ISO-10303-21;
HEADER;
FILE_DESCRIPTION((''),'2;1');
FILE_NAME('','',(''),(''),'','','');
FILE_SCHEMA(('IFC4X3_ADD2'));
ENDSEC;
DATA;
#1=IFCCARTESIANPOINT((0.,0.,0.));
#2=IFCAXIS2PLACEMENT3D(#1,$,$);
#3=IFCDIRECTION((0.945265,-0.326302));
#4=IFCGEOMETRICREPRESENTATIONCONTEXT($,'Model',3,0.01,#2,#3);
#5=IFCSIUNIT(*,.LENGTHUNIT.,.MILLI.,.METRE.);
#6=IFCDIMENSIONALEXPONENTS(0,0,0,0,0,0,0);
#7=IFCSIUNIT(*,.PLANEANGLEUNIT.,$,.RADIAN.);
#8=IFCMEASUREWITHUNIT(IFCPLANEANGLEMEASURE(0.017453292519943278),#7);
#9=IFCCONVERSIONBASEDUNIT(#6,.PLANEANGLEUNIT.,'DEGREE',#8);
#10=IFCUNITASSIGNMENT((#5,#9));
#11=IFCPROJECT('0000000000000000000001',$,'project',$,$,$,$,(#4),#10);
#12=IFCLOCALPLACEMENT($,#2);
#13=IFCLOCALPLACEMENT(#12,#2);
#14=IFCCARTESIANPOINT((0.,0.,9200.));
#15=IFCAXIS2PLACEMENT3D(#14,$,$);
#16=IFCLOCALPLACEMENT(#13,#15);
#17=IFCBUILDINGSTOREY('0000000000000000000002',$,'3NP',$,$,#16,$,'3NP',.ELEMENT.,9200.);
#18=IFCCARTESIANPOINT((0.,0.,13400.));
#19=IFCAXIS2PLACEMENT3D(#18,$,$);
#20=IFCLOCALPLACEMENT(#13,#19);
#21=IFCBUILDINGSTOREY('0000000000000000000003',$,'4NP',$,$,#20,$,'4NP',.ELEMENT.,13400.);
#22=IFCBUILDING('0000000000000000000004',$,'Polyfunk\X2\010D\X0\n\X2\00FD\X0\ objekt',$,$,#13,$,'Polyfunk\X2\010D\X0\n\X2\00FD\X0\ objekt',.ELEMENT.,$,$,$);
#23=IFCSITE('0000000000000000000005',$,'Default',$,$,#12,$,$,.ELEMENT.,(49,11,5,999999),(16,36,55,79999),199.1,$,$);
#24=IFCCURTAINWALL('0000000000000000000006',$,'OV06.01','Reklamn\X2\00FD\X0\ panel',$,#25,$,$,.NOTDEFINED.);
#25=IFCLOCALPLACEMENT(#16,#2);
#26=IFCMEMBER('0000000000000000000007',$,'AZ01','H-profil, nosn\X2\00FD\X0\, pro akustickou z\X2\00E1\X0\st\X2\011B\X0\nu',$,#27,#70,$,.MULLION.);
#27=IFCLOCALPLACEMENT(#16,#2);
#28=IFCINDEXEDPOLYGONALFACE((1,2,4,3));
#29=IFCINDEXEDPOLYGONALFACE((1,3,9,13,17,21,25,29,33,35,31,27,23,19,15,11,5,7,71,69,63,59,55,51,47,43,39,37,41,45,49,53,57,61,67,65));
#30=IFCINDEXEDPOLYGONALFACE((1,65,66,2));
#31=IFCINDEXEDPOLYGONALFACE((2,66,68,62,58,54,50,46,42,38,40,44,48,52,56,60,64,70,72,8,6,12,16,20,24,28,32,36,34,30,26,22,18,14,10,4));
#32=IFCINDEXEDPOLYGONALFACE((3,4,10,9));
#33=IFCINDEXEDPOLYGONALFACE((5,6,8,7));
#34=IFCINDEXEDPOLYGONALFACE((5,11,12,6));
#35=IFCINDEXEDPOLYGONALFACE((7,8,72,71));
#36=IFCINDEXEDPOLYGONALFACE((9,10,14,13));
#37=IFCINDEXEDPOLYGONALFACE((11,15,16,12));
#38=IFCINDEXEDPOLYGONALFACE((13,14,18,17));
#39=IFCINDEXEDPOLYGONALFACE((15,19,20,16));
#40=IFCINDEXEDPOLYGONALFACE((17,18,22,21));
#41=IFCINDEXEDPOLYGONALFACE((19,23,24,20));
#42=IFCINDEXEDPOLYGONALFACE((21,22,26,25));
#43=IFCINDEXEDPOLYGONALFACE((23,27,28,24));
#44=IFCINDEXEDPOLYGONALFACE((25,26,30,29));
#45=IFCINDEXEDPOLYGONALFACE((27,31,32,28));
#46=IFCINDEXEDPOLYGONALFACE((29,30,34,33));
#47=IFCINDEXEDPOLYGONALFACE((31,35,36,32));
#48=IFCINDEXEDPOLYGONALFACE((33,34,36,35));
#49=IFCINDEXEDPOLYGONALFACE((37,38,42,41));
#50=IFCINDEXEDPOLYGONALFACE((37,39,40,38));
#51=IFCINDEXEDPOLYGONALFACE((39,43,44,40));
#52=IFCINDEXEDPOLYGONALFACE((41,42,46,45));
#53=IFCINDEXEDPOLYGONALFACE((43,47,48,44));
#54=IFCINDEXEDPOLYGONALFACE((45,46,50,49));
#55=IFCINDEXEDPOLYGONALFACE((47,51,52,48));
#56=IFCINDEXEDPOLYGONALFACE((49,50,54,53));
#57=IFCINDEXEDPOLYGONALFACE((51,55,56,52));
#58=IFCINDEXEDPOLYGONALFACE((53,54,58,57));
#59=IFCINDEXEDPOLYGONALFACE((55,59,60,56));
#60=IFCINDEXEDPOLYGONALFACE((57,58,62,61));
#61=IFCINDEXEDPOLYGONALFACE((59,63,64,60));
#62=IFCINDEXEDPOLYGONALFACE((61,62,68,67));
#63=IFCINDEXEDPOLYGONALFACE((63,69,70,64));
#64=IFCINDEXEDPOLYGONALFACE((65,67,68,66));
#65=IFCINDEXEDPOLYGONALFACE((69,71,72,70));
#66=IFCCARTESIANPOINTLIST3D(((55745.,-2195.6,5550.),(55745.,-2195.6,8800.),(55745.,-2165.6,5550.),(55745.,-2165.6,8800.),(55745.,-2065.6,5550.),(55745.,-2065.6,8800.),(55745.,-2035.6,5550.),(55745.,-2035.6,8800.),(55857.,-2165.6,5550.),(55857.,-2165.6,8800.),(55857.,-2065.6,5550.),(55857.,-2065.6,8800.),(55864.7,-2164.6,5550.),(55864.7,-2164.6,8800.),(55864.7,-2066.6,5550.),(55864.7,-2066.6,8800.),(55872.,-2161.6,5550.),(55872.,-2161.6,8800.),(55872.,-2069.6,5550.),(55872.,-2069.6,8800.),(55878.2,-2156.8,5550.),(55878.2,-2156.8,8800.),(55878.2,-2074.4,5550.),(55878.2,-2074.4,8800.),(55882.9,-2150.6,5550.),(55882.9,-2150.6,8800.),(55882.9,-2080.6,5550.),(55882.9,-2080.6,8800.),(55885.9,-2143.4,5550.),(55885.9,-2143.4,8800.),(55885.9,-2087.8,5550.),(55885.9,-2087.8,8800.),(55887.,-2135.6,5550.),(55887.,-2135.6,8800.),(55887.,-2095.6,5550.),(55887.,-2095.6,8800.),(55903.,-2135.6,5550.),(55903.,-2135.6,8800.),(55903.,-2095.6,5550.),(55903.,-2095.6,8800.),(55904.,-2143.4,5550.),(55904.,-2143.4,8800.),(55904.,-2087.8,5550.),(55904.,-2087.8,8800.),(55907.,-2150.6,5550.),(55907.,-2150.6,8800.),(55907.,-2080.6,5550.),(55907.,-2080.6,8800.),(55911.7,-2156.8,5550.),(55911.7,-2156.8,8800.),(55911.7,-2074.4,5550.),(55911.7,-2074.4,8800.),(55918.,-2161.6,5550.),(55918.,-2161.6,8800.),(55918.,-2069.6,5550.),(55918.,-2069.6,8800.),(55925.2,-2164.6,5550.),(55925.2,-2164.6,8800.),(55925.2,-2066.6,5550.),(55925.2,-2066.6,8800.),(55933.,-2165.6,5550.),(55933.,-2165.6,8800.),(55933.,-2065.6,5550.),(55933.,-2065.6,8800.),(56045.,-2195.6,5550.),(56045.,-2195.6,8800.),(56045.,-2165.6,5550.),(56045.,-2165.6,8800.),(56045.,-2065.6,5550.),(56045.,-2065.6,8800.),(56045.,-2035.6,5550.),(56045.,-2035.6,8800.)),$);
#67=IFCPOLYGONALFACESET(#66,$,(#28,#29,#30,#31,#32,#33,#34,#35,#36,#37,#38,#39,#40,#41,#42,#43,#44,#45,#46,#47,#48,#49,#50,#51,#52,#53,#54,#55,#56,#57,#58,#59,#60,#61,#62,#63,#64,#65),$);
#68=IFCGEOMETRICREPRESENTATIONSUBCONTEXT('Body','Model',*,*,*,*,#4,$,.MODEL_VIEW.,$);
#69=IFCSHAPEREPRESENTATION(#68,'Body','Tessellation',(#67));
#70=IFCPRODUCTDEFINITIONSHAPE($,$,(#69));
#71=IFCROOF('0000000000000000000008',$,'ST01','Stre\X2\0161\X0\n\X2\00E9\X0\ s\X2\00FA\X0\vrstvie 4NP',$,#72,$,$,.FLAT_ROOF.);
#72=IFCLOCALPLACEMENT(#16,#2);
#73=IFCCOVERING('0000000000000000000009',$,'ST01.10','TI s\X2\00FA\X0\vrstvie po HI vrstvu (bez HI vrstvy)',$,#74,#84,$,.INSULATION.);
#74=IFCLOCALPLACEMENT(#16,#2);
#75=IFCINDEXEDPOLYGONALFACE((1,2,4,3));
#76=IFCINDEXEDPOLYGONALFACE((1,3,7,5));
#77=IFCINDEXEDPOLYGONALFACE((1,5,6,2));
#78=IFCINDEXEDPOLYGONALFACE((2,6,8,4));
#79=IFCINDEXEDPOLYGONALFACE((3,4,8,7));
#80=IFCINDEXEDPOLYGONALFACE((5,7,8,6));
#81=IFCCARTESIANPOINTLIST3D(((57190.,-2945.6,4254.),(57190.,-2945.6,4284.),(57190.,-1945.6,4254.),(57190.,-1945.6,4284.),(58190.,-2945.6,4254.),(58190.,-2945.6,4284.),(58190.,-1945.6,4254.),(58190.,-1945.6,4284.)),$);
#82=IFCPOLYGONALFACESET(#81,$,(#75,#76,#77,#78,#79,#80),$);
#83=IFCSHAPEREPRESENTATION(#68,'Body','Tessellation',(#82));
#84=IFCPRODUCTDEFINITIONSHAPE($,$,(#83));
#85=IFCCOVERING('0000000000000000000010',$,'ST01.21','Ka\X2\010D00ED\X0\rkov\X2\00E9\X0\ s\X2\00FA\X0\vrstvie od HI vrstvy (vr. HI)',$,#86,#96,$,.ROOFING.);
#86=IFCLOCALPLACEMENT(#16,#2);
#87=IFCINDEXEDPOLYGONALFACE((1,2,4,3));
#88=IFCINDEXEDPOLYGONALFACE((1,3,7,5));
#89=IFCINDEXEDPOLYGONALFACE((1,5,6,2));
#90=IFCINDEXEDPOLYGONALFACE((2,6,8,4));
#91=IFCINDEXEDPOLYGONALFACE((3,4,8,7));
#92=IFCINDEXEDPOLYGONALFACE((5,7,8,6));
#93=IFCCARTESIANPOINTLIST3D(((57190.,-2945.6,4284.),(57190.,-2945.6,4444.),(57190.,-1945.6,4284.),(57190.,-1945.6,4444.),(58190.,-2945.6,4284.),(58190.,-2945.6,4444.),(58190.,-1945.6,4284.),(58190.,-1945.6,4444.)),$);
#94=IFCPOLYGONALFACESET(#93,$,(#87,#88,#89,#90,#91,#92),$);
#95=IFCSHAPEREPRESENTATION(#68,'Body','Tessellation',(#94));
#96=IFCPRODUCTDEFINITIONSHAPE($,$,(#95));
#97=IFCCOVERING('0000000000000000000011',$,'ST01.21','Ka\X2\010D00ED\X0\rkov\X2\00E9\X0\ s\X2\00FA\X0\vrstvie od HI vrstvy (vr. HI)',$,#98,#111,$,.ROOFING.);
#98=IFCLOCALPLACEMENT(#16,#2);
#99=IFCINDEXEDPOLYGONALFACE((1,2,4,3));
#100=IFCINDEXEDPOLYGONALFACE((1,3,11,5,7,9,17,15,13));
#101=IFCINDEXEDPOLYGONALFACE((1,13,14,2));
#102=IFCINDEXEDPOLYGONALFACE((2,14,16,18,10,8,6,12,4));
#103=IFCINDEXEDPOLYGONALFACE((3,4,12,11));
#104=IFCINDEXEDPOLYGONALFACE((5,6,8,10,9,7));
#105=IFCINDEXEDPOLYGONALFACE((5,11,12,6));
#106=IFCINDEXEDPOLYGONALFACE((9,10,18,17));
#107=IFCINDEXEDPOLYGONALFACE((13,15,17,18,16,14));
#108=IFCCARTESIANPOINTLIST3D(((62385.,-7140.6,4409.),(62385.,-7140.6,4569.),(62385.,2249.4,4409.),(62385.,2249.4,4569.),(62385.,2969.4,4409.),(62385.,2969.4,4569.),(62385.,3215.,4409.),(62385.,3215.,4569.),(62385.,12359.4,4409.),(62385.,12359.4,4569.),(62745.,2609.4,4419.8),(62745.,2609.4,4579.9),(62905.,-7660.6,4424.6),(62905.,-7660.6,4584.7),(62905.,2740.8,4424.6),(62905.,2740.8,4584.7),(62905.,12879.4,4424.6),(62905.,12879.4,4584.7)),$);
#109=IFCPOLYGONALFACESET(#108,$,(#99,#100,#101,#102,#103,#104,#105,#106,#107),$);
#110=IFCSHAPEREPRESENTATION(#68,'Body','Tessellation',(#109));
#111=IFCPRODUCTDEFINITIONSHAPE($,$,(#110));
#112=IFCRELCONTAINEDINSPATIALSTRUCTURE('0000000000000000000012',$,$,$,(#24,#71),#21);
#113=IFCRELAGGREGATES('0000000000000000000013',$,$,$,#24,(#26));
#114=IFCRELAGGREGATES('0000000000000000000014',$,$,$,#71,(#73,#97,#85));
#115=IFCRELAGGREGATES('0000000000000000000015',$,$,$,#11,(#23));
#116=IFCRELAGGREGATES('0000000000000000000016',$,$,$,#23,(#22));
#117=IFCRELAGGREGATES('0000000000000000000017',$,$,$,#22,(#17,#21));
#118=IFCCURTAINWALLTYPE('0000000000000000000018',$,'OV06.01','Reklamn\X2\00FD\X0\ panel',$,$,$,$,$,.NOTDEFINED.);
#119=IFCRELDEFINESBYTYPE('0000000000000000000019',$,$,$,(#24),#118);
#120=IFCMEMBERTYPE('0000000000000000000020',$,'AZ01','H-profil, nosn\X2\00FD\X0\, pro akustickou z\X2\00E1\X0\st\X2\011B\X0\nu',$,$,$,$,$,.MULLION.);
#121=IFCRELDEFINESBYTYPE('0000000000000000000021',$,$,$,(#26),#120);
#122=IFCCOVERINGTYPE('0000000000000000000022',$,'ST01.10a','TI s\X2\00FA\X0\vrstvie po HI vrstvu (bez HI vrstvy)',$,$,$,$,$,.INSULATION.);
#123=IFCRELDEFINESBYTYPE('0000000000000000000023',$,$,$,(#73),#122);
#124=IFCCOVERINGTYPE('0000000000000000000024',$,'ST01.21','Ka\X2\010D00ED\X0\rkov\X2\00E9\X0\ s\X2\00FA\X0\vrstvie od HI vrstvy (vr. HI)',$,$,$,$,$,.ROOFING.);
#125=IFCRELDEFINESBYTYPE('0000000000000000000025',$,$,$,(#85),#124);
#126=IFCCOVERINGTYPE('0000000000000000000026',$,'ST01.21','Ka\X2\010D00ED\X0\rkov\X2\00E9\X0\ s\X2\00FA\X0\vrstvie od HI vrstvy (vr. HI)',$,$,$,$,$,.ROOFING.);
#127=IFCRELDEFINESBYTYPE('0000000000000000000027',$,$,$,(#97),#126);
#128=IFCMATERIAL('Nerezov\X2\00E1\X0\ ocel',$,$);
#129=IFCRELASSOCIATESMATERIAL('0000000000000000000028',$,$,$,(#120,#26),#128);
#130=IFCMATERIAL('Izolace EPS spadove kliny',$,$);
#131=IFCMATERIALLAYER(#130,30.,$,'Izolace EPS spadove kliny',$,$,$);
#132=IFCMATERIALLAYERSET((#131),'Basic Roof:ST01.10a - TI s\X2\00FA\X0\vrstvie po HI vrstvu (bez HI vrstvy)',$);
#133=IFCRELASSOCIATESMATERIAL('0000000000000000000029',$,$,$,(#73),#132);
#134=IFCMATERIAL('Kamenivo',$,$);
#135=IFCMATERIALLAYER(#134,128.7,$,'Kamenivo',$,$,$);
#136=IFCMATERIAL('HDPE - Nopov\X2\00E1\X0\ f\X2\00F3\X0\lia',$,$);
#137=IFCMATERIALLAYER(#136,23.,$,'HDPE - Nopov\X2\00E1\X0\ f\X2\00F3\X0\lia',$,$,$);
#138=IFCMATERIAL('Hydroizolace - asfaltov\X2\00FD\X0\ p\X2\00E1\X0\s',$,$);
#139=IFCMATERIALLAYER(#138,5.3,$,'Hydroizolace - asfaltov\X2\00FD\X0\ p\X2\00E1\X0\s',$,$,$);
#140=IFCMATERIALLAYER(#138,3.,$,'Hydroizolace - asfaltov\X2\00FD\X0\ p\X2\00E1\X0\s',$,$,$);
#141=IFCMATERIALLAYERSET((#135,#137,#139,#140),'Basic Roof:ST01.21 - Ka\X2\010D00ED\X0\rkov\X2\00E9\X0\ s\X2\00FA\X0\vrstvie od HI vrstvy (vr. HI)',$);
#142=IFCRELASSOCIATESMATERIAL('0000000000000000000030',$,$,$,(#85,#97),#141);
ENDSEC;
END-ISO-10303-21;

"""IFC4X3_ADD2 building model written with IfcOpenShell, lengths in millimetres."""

from ifc_helpers import new_model, entity, si_unit, converted_unit, direction, frame, frame_2d, origin, origin_2d_with_axis, place, context, subcontext, project, spatial, polyline, circle_curve, parameter, trimmed, segment, composite_curve, rectangle, outline, extrude, source, transform, mapped, material, layer, layer_set, material_profile, profile_set, profile_usage, type_object, element, aggregate, save


model = new_model("IFC4X3_ADD2")

# Units and contexts
model_context = context("Model", 3, precision=0.01, world=origin(), true_north=direction((0.945265, -0.326302)))
body_context = subcontext(model_context, "Body", "Model", "MODEL_VIEW")
ifc_project = project(units=[si_unit("LENGTHUNIT", "METRE", prefix="MILLI"), converted_unit("PLANEANGLEUNIT", "DEGREE", entity("IfcPlaneAngleMeasure", 0.017453292519943278), si_unit("PLANEANGLEUNIT", "RADIAN"), dimensions=[0, 0, 0, 0, 0, 0, 0])], contexts=[model_context])

# Site, building, storey
site_placement = place(None, origin())
site = spatial("IfcSite", under=ifc_project, at=site_placement, Name="Default", CompositionType="ELEMENT", RefLatitude=(49, 11, 5, 999999), RefLongitude=(16, 36, 55, 79999), RefElevation=199.1)
building_placement = place(site_placement, origin())
building = spatial("IfcBuilding", under=site, at=building_placement, Name="Polyfunkčný objekt", LongName="Polyfunkčný objekt", CompositionType="ELEMENT")
storey_1_placement = place(building_placement, frame((0.0, 0.0, 9200.0)))
storey_1 = spatial("IfcBuildingStorey", under=building, at=storey_1_placement, Name="3NP", LongName="3NP", CompositionType="ELEMENT", Elevation=9200.0)

# Shared definitions
storey_2_placement = place(building_placement, frame((0.0, 0.0, 13400.0)))
storey_2 = spatial("IfcBuildingStorey", under=building, at=storey_2_placement, Name="4NP", LongName="4NP", CompositionType="ELEMENT", Elevation=13400.0)

# Curtain wall, member
ifc_material_1 = material(Name="Nerezová ocel")
ifc_material_profile_1 = material_profile(ifc_material_1, outline(composite_curve([segment(polyline([(50.0, -150.0), (80.0, -150.0)]), True, "CONTINUOUS"), segment(polyline([(80.0, -150.0), (80.0, 150.0)]), True, "CONTINUOUS"), segment(polyline([(80.0, 150.0), (50.0, 150.0)]), True, "CONTINUOUS"), segment(polyline([(50.0, 150.0), (50.0, 38.0)]), True, "CONTINUOUS"), segment(trimmed(circle_curve(frame_2d((20.0, 38.0), x_axis=(0.0, 1.0)), 30.0), [parameter(180.0)], [parameter(270.0)], True, "PARAMETER"), False, "CONTINUOUS"), segment(polyline([(20.0, 8.0), (-20.0, 8.0)]), True, "CONTINUOUS"), segment(trimmed(circle_curve(frame_2d((-20.0, 38.0), x_axis=(0.0, 1.0)), 30.0), [parameter(90.0)], [parameter(180.0)], True, "PARAMETER"), False, "CONTINUOUS"), segment(polyline([(-50.0, 38.0), (-50.0, 150.0)]), True, "CONTINUOUS"), segment(polyline([(-50.0, 150.0), (-80.0, 150.0)]), True, "CONTINUOUS"), segment(polyline([(-80.0, 150.0), (-80.0, -150.0)]), True, "CONTINUOUS"), segment(polyline([(-80.0, -150.0), (-50.0, -150.0)]), True, "CONTINUOUS"), segment(polyline([(-50.0, -150.0), (-50.0, -38.0)]), True, "CONTINUOUS"), segment(trimmed(circle_curve(frame_2d((-20.0, -38.0), x_axis=(0.0, 1.0)), 30.0), [parameter(0.0)], [parameter(90.0)], True, "PARAMETER"), False, "CONTINUOUS"), segment(polyline([(-20.0, -8.0), (20.0, -8.0)]), True, "CONTINUOUS"), segment(trimmed(circle_curve(frame_2d((20.0, -38.0), x_axis=(0.0, 1.0)), 30.0), [parameter(270.0)], [parameter(0.0)], True, "PARAMETER"), False, "CONTINUOUS"), segment(polyline([(50.0, -38.0), (50.0, -150.0)]), True, "CONTINUOUS")], self_intersect=False)), Name="Profil zástena")
ifc_profile_set_1 = profile_set([ifc_material_profile_1], Name="Profil zástena")
ifc_profile_usage_1 = profile_usage(ifc_profile_set_1)
member_type_1 = type_object("IfcMemberType", Name="AZ01", Description="H-profil, nosný, pro akustickou zástěnu", PredefinedType="MULLION", material=ifc_profile_set_1)
curtain_wall_type_1 = type_object("IfcCurtainWallType", Name="OV06.01", Description="Reklamný panel", PredefinedType="NOTDEFINED")
curtain_wall_1_placement = place(storey_2_placement, frame((0.0, 0.0, -13400.0)))
curtain_wall_1 = element("IfcCurtainWall", 1, at=curtain_wall_1_placement, inside=storey_2, type_object=curtain_wall_type_1, Name="OV06.01", Description="Reklamný panel", PredefinedType="NOTDEFINED")
shared_shape_1 = source(origin(), body_context, "Body", "SweptSolid", [
    extrude(outline(composite_curve([segment(polyline([(-150.0, -50.0), (-150.0, -80.0)]), True, "CONTINUOUS"), segment(polyline([(-150.0, -80.0), (150.0, -80.0)]), True, "CONTINUOUS"), segment(polyline([(150.0, -80.0), (150.0, -50.0)]), True, "CONTINUOUS"), segment(polyline([(150.0, -50.0), (38.0, -50.0)]), True, "CONTINUOUS"), segment(trimmed(circle_curve(frame_2d((38.0, -20.0), x_axis=(1.0, 0.0)), 30.0), [parameter(180.0)], [parameter(270.0)], True, "PARAMETER"), False, "CONTINUOUS"), segment(polyline([(8.0, -20.0), (8.0, 20.0)]), True, "CONTINUOUS"), segment(trimmed(circle_curve(frame_2d((38.0, 20.0), x_axis=(1.0, 0.0)), 30.0), [parameter(90.0)], [parameter(180.0)], True, "PARAMETER"), False, "CONTINUOUS"), segment(polyline([(38.0, 50.0), (150.0, 50.0)]), True, "CONTINUOUS"), segment(polyline([(150.0, 50.0), (150.0, 80.0)]), True, "CONTINUOUS"), segment(polyline([(150.0, 80.0), (-150.0, 80.0)]), True, "CONTINUOUS"), segment(polyline([(-150.0, 80.0), (-150.0, 50.0)]), True, "CONTINUOUS"), segment(polyline([(-150.0, 50.0), (-38.0, 50.0)]), True, "CONTINUOUS"), segment(trimmed(circle_curve(frame_2d((-38.0, 20.0), x_axis=(1.0, 0.0)), 30.0), [parameter(0.0)], [parameter(90.0)], True, "PARAMETER"), False, "CONTINUOUS"), segment(polyline([(-8.0, 20.0), (-8.0, -20.0)]), True, "CONTINUOUS"), segment(trimmed(circle_curve(frame_2d((-38.0, -20.0), x_axis=(1.0, 0.0)), 30.0), [parameter(270.0)], [parameter(0.0)], True, "PARAMETER"), False, "CONTINUOUS"), segment(polyline([(-38.0, -50.0), (-150.0, -50.0)]), True, "CONTINUOUS")], self_intersect=False)), frame((-150.0, 0.0, -3250.0), z_axis=(0.0, 0.0, -1.0), x_axis=(1.0, 0.0, 0.0)), (0.0, 0.0, -1.0), 3250.0),
])
member_1_placement = place(curtain_wall_1_placement, frame((56045.0, -2115.6, 14750.0), z_axis=(0.0, 0.0, -1.0), x_axis=(1.0, 0.0, 0.0)))
member_1 = element("IfcMember", 2, at=member_1_placement, type_object=member_type_1, material=ifc_profile_usage_1, Name="AZ01", Description="H-profil, nosný, pro akustickou zástěnu", PredefinedType="MULLION", context=body_context, shape_type="MappedRepresentation", body=[
    mapped(shared_shape_1, transform((0.0, 0.0, 0.0), scale=1.0)),
])
aggregate(curtain_wall_1, [member_1])

# Roof, coverings
roof = element("IfcRoof", 3, inside=storey_2, Name="ST01", Description="Strešné súvrstvie 4NP", PredefinedType="FLAT_ROOF")
ifc_material_2 = material(Name="HDPE - Nopová fólia")
ifc_material_3 = material(Name="Hydroizolace - asfaltový pás")
ifc_material_4 = material(Name="Izolace EPS spadove kliny")
ifc_layer_1 = layer(ifc_material_4, 30.0, Name="Izolace EPS spadove kliny")
ifc_layer_set_1 = layer_set([ifc_layer_1], Name="Basic Roof:ST01.10a - TI súvrstvie po HI vrstvu (bez HI vrstvy)")
covering_type_1 = type_object("IfcCoveringType", Name="ST01.10a", Description="TI súvrstvie po HI vrstvu (bez HI vrstvy)", PredefinedType="INSULATION")
placement_1 = place(storey_2_placement, frame((57190.0, -2945.6, 54.0)))
covering_1_placement = place(placement_1, origin())
covering_1 = element("IfcCovering", 4, at=covering_1_placement, type_object=covering_type_1, material=ifc_layer_set_1, Name="ST01.10", Description="TI súvrstvie po HI vrstvu (bez HI vrstvy)", PredefinedType="INSULATION", context=body_context, shape_type="SweptSolid", body=[
    extrude(rectangle(XDim=1000.0, YDim=1000.0, at=frame_2d((0.0, 0.0), x_axis=(-1.0, 0.0))), frame((500.0, 500.0, 0.0)), (0.0, 0.0, 1.0), 30.0),
])
ifc_material_5 = material(Name="Kamenivo")
ifc_layer_2 = layer(ifc_material_5, 128.7, Name="Kamenivo")
ifc_layer_3 = layer(ifc_material_2, 23.0, Name="HDPE - Nopová fólia")
ifc_layer_4 = layer(ifc_material_3, 5.3, Name="Hydroizolace - asfaltový pás")
ifc_layer_5 = layer(ifc_material_3, 3.0, Name="Hydroizolace - asfaltový pás")
ifc_layer_set_2 = layer_set([ifc_layer_2, ifc_layer_3, ifc_layer_4, ifc_layer_5], Name="Basic Roof:ST01.21 - Kačírkové súvrstvie od HI vrstvy (vr. HI)")
covering_type_2 = type_object("IfcCoveringType", Name="ST01.21", Description="Kačírkové súvrstvie od HI vrstvy (vr. HI)", PredefinedType="ROOFING")
covering_2_placement = place(storey_2_placement, frame((57190.0, -2945.6, 84.0)))
covering_2 = element("IfcCovering", 5, at=covering_2_placement, type_object=covering_type_2, material=ifc_layer_set_2, Name="ST01.21", Description="Kačírkové súvrstvie od HI vrstvy (vr. HI)", PredefinedType="ROOFING", context=body_context, shape_type="SweptSolid", body=[
    extrude(rectangle(XDim=1000.0, YDim=1000.0, at=origin_2d_with_axis()), frame((500.0, 500.0, 0.0), z_axis=(0.0, 0.0, 1.0), x_axis=(0.0, -1.0, 0.0)), (0.0, 0.0, 1.0), 160.0),
])
covering_type_3 = type_object("IfcCoveringType", Name="ST01.21", Description="Kačírkové súvrstvie od HI vrstvy (vr. HI)", PredefinedType="ROOFING")
placement_2 = place(storey_2_placement, frame((62385.0, -7660.6, 209.0)))
covering_3_placement = place(placement_2, origin())
covering_3 = element("IfcCovering", 6, at=covering_3_placement, type_object=covering_type_3, material=ifc_layer_set_2, Name="ST01.21", Description="Kačírkové súvrstvie od HI vrstvy (vr. HI)", PredefinedType="ROOFING", context=body_context, shape_type="SweptSolid", body=[
    extrude(outline(polyline([(-260.1, -9750.0), (260.1, -10270.0), (260.1, 131.4), (260.1, 10270.0), (-260.1, 9750.0), (-260.1, 605.6), (-260.1, 360.0), (100.0, 0.0), (-260.1, -360.0), (-260.1, -9750.0)])), frame((260.0, 10270.0, 7.8), z_axis=(-0.030015, 0.0, 0.999549), x_axis=(0.999549, 0.0, 0.030015)), (0.030015, 0.0, 0.999549), 160.1),
])
aggregate(roof, [covering_1, covering_3, covering_2])

save(model, "model.ifc")
